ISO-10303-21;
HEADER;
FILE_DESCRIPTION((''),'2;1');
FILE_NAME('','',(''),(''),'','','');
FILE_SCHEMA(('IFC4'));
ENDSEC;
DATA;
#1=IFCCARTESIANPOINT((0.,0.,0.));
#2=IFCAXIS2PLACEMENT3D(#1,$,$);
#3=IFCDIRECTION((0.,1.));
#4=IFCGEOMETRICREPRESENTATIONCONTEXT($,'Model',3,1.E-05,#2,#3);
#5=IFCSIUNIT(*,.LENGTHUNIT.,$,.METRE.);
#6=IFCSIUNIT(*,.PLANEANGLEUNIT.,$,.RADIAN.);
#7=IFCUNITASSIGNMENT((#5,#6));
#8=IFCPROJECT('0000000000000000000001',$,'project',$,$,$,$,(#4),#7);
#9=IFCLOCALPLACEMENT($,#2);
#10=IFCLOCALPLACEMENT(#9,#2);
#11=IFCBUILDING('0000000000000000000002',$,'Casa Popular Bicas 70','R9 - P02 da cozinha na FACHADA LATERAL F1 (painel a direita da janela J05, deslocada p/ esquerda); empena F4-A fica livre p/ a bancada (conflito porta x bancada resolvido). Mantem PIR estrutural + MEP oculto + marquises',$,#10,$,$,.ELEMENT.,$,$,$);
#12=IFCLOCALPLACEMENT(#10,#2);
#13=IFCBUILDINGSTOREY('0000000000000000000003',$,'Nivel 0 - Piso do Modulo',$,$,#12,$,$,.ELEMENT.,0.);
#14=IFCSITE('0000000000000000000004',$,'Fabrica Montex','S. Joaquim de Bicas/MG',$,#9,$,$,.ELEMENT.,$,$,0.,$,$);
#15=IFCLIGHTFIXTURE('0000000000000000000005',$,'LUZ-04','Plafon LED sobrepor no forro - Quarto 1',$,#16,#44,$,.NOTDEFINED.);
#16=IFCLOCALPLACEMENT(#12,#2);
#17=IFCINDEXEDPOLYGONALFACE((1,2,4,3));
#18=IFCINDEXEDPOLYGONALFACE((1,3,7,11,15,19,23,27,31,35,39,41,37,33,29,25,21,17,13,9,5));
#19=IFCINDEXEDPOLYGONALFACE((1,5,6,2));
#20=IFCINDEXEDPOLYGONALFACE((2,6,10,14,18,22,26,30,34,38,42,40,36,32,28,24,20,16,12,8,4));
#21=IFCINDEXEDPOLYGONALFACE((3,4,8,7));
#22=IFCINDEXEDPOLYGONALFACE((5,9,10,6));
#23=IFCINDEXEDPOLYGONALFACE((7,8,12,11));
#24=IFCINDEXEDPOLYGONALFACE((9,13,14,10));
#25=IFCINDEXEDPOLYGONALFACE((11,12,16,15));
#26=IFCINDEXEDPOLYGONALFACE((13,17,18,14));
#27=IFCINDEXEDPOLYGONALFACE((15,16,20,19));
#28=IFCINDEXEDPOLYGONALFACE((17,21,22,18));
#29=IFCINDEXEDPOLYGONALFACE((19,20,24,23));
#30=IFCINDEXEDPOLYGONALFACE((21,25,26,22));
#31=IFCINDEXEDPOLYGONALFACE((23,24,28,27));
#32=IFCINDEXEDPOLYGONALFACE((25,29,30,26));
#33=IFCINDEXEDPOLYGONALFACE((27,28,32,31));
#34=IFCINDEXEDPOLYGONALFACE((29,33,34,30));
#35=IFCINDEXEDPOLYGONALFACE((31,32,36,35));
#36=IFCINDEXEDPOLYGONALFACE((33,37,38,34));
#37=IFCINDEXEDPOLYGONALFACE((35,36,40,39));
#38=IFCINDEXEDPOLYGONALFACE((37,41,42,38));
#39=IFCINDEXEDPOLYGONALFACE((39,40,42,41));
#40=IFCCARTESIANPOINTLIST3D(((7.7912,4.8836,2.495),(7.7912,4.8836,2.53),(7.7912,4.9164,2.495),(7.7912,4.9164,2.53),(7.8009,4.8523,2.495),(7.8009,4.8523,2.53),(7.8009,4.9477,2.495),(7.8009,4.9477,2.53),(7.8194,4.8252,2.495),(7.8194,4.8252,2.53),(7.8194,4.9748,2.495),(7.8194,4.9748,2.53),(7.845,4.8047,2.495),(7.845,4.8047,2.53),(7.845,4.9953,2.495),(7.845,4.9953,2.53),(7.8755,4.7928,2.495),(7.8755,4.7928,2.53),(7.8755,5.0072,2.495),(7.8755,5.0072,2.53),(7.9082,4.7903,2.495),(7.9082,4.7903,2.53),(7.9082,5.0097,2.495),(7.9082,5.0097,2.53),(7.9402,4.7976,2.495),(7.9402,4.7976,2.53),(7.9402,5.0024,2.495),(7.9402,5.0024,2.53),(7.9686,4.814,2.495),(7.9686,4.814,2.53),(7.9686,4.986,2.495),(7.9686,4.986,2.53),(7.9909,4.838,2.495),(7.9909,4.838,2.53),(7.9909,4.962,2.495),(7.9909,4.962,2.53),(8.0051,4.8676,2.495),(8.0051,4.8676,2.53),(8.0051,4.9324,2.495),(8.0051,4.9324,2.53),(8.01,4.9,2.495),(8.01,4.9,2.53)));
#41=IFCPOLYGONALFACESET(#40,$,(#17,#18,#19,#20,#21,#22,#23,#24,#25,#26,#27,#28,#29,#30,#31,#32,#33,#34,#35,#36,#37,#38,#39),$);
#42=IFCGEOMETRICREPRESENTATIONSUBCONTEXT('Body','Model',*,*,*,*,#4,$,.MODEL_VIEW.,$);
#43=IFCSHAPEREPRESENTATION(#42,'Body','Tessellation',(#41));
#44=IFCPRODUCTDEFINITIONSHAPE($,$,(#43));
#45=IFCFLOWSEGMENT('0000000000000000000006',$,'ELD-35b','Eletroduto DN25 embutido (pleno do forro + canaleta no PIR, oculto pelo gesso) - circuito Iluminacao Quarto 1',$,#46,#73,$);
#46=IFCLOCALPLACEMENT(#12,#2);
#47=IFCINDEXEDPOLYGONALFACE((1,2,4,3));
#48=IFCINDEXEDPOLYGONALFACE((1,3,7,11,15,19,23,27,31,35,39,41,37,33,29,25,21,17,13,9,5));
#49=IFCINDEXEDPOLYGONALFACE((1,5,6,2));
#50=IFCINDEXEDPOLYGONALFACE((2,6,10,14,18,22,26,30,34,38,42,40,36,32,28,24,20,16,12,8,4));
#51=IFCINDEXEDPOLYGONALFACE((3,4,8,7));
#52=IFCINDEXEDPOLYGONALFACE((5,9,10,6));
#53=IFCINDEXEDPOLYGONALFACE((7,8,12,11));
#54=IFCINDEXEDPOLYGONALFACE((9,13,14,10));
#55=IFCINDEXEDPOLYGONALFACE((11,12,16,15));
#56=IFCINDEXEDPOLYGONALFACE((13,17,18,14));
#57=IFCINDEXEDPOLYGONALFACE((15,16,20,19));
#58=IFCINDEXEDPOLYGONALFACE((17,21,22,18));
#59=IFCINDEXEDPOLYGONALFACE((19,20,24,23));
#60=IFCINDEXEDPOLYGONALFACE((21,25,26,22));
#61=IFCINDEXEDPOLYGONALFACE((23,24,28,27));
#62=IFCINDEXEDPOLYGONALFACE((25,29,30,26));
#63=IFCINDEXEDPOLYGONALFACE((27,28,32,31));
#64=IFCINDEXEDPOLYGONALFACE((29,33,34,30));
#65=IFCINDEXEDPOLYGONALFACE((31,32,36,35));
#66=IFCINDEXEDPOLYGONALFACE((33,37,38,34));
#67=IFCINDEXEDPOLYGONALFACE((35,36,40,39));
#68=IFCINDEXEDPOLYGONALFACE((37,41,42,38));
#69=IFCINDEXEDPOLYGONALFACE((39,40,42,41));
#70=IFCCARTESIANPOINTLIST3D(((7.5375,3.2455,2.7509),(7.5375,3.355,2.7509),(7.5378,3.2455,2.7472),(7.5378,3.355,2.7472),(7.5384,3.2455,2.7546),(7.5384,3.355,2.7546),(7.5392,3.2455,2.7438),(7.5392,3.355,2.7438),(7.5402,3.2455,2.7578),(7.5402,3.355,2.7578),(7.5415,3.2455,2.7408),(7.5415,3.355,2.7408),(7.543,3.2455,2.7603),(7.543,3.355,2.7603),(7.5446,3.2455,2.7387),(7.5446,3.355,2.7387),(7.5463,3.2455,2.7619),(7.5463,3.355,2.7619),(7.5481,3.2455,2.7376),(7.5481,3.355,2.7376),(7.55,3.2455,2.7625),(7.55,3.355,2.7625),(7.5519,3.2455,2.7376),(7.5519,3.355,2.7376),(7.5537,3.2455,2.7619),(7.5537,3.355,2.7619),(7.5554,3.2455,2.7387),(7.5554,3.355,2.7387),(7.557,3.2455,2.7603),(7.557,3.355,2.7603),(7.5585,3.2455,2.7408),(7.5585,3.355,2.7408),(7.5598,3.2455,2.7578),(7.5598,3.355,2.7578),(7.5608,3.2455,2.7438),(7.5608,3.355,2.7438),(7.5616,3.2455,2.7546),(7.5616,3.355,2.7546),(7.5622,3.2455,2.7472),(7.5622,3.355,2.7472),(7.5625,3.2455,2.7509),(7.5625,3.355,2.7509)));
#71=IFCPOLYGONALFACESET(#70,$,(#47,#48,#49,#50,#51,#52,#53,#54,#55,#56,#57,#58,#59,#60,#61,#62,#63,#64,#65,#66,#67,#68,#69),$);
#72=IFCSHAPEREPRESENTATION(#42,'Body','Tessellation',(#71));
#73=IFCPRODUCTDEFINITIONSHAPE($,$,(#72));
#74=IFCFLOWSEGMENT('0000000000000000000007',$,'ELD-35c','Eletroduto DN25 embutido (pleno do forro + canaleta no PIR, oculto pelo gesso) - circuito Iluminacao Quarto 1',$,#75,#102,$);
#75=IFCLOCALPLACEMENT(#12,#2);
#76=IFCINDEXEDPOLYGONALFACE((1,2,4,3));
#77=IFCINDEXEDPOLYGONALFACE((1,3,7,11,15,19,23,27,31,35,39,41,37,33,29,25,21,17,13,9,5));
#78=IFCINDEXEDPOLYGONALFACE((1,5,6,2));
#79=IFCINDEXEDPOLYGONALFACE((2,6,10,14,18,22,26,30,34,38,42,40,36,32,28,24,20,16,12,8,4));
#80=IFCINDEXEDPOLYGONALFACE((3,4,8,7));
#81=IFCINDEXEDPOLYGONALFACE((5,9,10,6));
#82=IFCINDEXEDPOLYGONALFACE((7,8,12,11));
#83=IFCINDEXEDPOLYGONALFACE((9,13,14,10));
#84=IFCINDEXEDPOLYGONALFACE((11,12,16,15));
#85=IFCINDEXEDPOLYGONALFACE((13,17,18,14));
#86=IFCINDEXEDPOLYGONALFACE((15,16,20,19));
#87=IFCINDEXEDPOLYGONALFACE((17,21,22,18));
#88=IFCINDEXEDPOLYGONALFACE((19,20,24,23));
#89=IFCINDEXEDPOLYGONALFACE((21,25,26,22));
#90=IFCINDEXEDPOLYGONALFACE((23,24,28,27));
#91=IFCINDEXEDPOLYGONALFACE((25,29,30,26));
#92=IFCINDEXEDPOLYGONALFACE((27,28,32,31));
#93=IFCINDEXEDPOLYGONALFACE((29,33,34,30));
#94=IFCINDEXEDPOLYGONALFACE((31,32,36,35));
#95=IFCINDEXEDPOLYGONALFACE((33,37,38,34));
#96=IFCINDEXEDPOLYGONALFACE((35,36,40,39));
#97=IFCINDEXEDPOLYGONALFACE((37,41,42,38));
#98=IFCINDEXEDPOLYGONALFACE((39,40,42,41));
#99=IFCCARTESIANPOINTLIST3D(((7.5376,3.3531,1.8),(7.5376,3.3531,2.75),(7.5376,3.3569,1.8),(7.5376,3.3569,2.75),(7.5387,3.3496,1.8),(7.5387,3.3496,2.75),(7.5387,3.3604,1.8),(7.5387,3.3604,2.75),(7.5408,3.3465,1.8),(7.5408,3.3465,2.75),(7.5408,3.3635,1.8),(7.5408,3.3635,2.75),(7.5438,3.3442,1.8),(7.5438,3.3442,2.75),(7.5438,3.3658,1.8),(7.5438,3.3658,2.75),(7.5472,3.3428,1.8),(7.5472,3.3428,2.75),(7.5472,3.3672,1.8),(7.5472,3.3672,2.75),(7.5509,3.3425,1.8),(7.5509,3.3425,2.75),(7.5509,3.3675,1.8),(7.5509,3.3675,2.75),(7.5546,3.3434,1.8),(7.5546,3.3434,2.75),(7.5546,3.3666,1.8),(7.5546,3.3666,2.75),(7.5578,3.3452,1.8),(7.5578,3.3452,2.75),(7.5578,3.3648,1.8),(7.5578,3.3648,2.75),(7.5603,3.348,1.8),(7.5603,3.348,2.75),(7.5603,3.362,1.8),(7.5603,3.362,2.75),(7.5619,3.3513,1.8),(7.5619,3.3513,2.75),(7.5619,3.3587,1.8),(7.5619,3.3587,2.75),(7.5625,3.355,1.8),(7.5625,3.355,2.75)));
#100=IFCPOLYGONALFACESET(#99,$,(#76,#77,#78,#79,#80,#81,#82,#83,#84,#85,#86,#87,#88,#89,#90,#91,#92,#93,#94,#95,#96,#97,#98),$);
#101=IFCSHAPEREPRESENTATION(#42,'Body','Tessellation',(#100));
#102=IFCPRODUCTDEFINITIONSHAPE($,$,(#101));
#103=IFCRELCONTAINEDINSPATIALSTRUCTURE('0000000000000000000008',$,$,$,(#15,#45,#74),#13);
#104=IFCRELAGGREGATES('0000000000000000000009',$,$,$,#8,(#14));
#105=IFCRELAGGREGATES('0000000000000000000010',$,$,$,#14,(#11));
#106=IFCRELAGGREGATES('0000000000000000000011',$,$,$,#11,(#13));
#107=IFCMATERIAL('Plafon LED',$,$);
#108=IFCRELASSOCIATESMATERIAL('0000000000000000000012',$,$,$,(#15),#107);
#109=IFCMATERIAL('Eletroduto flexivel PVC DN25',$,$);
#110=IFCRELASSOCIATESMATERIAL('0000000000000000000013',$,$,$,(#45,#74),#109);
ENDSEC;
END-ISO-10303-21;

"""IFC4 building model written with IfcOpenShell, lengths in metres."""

from ifc_helpers import new_model, si_unit, direction, frame, origin, origin_2d, place, context, subcontext, project, spatial, circle, extrude, material, element, save


model = new_model("IFC4")

# Units and contexts
model_context = context("Model", 3, precision=1e-05, world=origin(), true_north=direction((0.0, 1.0)))
body_context = subcontext(model_context, "Body", "Model", "MODEL_VIEW")
ifc_project = project(units=[si_unit("LENGTHUNIT", "METRE"), si_unit("PLANEANGLEUNIT", "RADIAN")], contexts=[model_context])

# Site, building, storey
site_placement = place(None, origin())
site = spatial("IfcSite", under=ifc_project, at=site_placement, Name="Fabrica Montex", Description="S. Joaquim de Bicas/MG", CompositionType="ELEMENT", RefElevation=0.0)
building_placement = place(site_placement, origin())
building = spatial("IfcBuilding", under=site, at=building_placement, Name="Casa Popular Bicas 70", Description="R9 - P02 da cozinha na FACHADA LATERAL F1 (painel a direita da janela J05, deslocada p/ esquerda); empena F4-A fica livre p/ a bancada (conflito porta x bancada resolvido). Mantem PIR estrutural + MEP oculto + marquises", CompositionType="ELEMENT")
storey_placement = place(building_placement, origin())
storey = spatial("IfcBuildingStorey", under=building, at=storey_placement, Name="Nivel 0 - Piso do Modulo", CompositionType="ELEMENT", Elevation=0.0)

# Shared definitions
ifc_material_1 = material(Name="Eletroduto flexivel PVC DN25")

# Light fixture
ifc_material_2 = material(Name="Plafon LED")
light_fixture_placement = place(storey_placement, frame((7.9, 4.9, 2.495)))
element("IfcLightFixture", 1, at=light_fixture_placement, inside=storey, material=ifc_material_2, Name="LUZ-04", Description="Plafon LED sobrepor no forro - Quarto 1", PredefinedType="NOTDEFINED", context=body_context, shape_type="SweptSolid", body=[
    extrude(circle(Radius=0.11, at=origin_2d()), origin(), (0.0, 0.0, 1.0), 0.035),
])

# Flow segments
flow_segment_1_placement = place(storey_placement, frame((7.55, 3.2455, 2.75), z_axis=(0.0, 1.0, 0.0), x_axis=(0.0, 0.0, 1.0)))
element("IfcFlowSegment", 2, at=flow_segment_1_placement, inside=storey, material=ifc_material_1, Name="ELD-35b", Description="Eletroduto DN25 embutido (pleno do forro + canaleta no PIR, oculto pelo gesso) - circuito Iluminacao Quarto 1", context=body_context, shape_type="SweptSolid", body=[
    extrude(circle(Radius=0.0125, at=origin_2d()), origin(), (0.0, 0.0, 1.0), 0.1095),
])
flow_segment_2_placement = place(storey_placement, frame((7.55, 3.355, 2.75), z_axis=(0.0, 0.0, -1.0), x_axis=(1.0, 0.0, 0.0)))
element("IfcFlowSegment", 3, at=flow_segment_2_placement, inside=storey, material=ifc_material_1, Name="ELD-35c", Description="Eletroduto DN25 embutido (pleno do forro + canaleta no PIR, oculto pelo gesso) - circuito Iluminacao Quarto 1", context=body_context, shape_type="SweptSolid", body=[
    extrude(circle(Radius=0.0125, at=origin_2d()), origin(), (0.0, 0.0, 1.0), 0.95),
])

save(model, "model.ifc")
